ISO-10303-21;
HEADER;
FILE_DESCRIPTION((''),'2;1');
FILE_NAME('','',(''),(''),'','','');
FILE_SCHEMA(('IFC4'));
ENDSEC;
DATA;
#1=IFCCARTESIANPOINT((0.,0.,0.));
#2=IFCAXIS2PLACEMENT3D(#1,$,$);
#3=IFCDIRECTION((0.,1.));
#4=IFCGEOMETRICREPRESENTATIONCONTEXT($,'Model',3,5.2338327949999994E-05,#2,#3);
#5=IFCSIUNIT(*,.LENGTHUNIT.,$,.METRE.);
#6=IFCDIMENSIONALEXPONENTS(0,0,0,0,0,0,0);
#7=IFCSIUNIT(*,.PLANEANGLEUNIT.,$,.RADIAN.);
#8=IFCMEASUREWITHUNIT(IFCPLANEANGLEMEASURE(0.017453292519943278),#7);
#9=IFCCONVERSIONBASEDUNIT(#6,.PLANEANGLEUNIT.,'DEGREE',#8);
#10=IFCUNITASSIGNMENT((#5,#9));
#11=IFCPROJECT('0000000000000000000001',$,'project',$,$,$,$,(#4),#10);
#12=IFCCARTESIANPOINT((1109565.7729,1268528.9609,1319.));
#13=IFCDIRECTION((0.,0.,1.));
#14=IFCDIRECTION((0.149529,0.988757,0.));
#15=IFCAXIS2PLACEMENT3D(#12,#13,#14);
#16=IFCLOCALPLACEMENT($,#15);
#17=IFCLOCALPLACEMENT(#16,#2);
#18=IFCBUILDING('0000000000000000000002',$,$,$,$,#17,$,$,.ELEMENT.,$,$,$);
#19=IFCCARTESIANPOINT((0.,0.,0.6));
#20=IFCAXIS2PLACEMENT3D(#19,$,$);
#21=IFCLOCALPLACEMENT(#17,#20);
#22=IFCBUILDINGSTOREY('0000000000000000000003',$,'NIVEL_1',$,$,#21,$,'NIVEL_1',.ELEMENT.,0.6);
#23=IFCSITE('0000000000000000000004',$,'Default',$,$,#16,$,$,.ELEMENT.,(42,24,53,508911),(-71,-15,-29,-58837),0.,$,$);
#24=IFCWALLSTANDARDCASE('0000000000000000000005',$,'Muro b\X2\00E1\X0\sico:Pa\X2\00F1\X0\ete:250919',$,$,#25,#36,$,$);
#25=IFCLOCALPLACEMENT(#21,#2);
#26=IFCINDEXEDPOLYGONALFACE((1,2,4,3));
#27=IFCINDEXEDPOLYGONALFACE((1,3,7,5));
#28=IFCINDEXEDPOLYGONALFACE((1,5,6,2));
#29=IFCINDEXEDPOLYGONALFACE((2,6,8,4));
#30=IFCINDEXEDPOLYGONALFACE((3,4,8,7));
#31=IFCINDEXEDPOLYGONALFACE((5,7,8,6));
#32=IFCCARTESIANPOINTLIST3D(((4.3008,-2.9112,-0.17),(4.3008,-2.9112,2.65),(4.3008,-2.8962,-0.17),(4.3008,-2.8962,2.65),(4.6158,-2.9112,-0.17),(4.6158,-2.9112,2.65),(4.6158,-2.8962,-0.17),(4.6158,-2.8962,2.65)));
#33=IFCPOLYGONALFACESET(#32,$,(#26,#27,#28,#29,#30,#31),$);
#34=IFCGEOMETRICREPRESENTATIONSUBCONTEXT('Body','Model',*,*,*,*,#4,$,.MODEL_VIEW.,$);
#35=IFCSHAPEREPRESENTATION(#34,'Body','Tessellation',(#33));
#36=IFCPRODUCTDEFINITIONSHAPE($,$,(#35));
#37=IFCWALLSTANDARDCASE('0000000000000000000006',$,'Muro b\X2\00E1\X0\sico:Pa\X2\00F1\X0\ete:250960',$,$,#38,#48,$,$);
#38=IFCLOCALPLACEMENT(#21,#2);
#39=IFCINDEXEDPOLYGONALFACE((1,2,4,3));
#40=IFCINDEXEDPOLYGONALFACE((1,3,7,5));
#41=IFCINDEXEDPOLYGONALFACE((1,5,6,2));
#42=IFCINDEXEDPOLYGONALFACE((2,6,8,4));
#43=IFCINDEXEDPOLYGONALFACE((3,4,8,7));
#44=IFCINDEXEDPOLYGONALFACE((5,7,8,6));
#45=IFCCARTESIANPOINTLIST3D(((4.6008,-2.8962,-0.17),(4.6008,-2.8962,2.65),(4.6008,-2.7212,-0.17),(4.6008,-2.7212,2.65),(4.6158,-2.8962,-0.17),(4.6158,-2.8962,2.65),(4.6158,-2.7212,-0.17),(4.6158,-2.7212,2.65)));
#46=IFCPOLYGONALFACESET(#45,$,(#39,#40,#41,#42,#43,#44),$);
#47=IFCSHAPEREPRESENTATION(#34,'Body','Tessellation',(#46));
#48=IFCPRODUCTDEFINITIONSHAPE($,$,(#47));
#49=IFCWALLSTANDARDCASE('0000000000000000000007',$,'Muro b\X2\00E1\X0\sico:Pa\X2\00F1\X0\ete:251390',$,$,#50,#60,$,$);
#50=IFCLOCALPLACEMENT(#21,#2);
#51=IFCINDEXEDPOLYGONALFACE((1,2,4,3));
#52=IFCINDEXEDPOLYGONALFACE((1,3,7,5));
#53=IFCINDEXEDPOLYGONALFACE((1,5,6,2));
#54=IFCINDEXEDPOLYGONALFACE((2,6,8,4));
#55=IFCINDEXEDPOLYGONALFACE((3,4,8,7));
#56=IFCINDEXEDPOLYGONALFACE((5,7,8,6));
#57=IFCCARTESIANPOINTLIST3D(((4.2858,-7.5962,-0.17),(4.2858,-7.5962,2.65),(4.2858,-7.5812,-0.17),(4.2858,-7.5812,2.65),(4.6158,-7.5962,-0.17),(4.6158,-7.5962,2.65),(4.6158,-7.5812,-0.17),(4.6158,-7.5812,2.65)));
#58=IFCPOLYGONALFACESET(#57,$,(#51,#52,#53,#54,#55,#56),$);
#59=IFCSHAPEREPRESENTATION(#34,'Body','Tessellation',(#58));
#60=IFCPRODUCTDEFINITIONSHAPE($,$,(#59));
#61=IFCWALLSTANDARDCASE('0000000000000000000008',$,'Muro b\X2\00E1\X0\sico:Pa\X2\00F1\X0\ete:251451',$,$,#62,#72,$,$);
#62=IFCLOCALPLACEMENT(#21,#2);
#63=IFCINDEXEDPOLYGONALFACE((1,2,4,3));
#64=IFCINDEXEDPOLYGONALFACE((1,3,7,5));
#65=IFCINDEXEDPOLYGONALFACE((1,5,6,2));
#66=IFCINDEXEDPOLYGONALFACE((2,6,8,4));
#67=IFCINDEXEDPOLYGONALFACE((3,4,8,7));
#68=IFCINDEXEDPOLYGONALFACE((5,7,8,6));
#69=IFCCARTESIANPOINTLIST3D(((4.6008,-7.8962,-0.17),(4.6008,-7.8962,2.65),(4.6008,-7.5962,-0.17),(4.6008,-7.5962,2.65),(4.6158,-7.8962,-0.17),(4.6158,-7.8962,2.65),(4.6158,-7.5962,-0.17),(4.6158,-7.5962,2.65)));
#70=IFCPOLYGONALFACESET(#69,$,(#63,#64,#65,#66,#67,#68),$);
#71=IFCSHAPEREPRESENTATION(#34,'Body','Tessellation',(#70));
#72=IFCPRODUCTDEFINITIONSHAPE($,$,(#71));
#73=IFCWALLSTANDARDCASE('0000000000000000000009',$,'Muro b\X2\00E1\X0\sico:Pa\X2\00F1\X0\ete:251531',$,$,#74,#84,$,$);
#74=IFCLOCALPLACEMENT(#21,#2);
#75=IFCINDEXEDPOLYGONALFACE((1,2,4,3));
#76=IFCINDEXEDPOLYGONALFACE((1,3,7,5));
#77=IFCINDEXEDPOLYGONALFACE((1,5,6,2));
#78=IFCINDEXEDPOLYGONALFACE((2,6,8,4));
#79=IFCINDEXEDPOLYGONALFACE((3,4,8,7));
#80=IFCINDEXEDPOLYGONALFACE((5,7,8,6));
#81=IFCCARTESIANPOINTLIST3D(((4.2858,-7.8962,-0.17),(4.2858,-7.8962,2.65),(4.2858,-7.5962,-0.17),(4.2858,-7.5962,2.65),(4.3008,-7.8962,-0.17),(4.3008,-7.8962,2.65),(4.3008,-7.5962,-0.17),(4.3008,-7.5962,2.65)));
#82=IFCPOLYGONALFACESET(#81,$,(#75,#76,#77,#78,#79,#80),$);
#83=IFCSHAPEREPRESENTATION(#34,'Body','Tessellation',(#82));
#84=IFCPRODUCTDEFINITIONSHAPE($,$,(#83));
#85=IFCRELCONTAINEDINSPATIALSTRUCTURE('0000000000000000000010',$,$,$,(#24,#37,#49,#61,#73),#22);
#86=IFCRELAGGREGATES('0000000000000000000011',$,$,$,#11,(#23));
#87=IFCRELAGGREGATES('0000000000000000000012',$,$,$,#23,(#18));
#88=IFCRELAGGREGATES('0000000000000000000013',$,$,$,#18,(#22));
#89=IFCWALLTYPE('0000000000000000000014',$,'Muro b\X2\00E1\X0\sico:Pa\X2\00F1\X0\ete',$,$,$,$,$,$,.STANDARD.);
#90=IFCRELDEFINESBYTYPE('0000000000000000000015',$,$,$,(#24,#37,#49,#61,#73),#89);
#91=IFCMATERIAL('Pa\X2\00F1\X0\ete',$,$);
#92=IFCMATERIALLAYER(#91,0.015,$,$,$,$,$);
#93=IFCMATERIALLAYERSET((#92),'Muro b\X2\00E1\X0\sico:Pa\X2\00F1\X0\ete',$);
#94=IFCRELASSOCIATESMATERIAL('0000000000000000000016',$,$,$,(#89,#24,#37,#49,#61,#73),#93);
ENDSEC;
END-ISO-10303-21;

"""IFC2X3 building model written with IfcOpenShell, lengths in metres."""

from ifc_helpers import new_model, entity, si_unit, converted_unit, direction, frame, frame_2d, origin, place, context, subcontext, project, spatial, rectangle, extrude, material, layer, layer_set, layer_usage, type_object, element, save


model = new_model("IFC2X3")

# Units and contexts
model_context = context("Model", 3, precision=5.2338327949999994e-05, world=origin(), true_north=direction((0.0, 1.0)))
body_context = subcontext(model_context, "Body", "Model", "MODEL_VIEW")
ifc_project = project(units=[si_unit("LENGTHUNIT", "METRE"), converted_unit("PLANEANGLEUNIT", "DEGREE", entity("IfcPlaneAngleMeasure", 0.017453292519943278), si_unit("PLANEANGLEUNIT", "RADIAN"), dimensions=[0, 0, 0, 0, 0, 0, 0])], contexts=[model_context])

# Site, building, storey
site_placement = place(None, frame((1109565.7729, 1268528.9609, 1319.0), z_axis=(0.0, 0.0, 1.0), x_axis=(0.149529, 0.988757, 0.0)))
site = spatial("IfcSite", under=ifc_project, at=site_placement, Name="Default", CompositionType="ELEMENT", RefLatitude=(42, 24, 53, 508911), RefLongitude=(-71, -15, -29, -58837), RefElevation=0.0)
building_placement = place(site_placement, origin())
building = spatial("IfcBuilding", under=site, at=building_placement, CompositionType="ELEMENT")
storey_placement = place(building_placement, frame((0.0, 0.0, 0.6)))
storey = spatial("IfcBuildingStorey", under=building, at=storey_placement, Name="NIVEL_1", LongName="NIVEL_1", CompositionType="ELEMENT", Elevation=0.6)

# Shared definitions
ifc_material_1 = material(Name="Pañete")

# Walls
ifc_layer_1 = layer(ifc_material_1, 0.015)
ifc_layer_set_1 = layer_set([ifc_layer_1], Name="Muro básico:Pañete")
wall_type_1 = type_object("IfcWallType", Name="Muro básico:Pañete", PredefinedType="STANDARD", material=ifc_layer_set_1)
ifc_layer_usage_1 = layer_usage(ifc_layer_set_1, "AXIS2", "POSITIVE", -0.0075)
wall_1_placement = place(storey_placement, frame((4.3008, -2.9037, -0.17)))
element("IfcWallStandardCase", 1, at=wall_1_placement, inside=storey, type_object=wall_type_1, material=ifc_layer_usage_1, Name="Muro básico:Pañete:250919", context=body_context, shape_type="SweptSolid", body=[
    extrude(rectangle(XDim=0.315, YDim=0.015, at=frame_2d((0.1575, 0.0), x_axis=(-1.0, 0.0))), origin(), (0.0, 0.0, 1.0), 2.82),
])
ifc_layer_usage_2 = layer_usage(ifc_layer_set_1, "AXIS2", "POSITIVE", -0.0075)
wall_2_placement = place(storey_placement, frame((4.6083, -2.8962, -0.17), z_axis=(0.0, 0.0, 1.0), x_axis=(0.0, 1.0, 0.0)))
element("IfcWallStandardCase", 2, at=wall_2_placement, inside=storey, type_object=wall_type_1, material=ifc_layer_usage_2, Name="Muro básico:Pañete:250960", context=body_context, shape_type="SweptSolid", body=[
    extrude(rectangle(XDim=0.175, YDim=0.015, at=frame_2d((0.0875, 0.0), x_axis=(-1.0, 0.0))), origin(), (0.0, 0.0, 1.0), 2.82),
])
ifc_layer_usage_3 = layer_usage(ifc_layer_set_1, "AXIS2", "NEGATIVE", 0.0075)
wall_3_placement = place(storey_placement, frame((4.2858, -7.5887, -0.17)))
element("IfcWallStandardCase", 3, at=wall_3_placement, inside=storey, type_object=wall_type_1, material=ifc_layer_usage_3, Name="Muro básico:Pañete:251390", context=body_context, shape_type="SweptSolid", body=[
    extrude(rectangle(XDim=0.33, YDim=0.015, at=frame_2d((0.165, 0.0), x_axis=(-1.0, 0.0))), origin(), (0.0, 0.0, 1.0), 2.82),
])
ifc_layer_usage_4 = layer_usage(ifc_layer_set_1, "AXIS2", "NEGATIVE", 0.0075)
wall_4_placement = place(storey_placement, frame((4.6083, -7.5962, -0.17), z_axis=(0.0, 0.0, 1.0), x_axis=(0.0, -1.0, 0.0)))
element("IfcWallStandardCase", 4, at=wall_4_placement, inside=storey, type_object=wall_type_1, material=ifc_layer_usage_4, Name="Muro básico:Pañete:251451", context=body_context, shape_type="SweptSolid", body=[
    extrude(rectangle(XDim=0.3, YDim=0.015, at=frame_2d((0.15, 0.0), x_axis=(-1.0, 0.0))), origin(), (0.0, 0.0, 1.0), 2.82),
])
ifc_layer_usage_5 = layer_usage(ifc_layer_set_1, "AXIS2", "NEGATIVE", 0.0075)
wall_5_placement = place(storey_placement, frame((4.2933, -7.8962, -0.17), z_axis=(0.0, 0.0, 1.0), x_axis=(0.0, 1.0, 0.0)))
element("IfcWallStandardCase", 5, at=wall_5_placement, inside=storey, type_object=wall_type_1, material=ifc_layer_usage_5, Name="Muro básico:Pañete:251531", context=body_context, shape_type="SweptSolid", body=[
    extrude(rectangle(XDim=0.3, YDim=0.015, at=frame_2d((0.15, 0.0), x_axis=(-1.0, 0.0))), origin(), (0.0, 0.0, 1.0), 2.82),
])

save(model, "model.ifc")
